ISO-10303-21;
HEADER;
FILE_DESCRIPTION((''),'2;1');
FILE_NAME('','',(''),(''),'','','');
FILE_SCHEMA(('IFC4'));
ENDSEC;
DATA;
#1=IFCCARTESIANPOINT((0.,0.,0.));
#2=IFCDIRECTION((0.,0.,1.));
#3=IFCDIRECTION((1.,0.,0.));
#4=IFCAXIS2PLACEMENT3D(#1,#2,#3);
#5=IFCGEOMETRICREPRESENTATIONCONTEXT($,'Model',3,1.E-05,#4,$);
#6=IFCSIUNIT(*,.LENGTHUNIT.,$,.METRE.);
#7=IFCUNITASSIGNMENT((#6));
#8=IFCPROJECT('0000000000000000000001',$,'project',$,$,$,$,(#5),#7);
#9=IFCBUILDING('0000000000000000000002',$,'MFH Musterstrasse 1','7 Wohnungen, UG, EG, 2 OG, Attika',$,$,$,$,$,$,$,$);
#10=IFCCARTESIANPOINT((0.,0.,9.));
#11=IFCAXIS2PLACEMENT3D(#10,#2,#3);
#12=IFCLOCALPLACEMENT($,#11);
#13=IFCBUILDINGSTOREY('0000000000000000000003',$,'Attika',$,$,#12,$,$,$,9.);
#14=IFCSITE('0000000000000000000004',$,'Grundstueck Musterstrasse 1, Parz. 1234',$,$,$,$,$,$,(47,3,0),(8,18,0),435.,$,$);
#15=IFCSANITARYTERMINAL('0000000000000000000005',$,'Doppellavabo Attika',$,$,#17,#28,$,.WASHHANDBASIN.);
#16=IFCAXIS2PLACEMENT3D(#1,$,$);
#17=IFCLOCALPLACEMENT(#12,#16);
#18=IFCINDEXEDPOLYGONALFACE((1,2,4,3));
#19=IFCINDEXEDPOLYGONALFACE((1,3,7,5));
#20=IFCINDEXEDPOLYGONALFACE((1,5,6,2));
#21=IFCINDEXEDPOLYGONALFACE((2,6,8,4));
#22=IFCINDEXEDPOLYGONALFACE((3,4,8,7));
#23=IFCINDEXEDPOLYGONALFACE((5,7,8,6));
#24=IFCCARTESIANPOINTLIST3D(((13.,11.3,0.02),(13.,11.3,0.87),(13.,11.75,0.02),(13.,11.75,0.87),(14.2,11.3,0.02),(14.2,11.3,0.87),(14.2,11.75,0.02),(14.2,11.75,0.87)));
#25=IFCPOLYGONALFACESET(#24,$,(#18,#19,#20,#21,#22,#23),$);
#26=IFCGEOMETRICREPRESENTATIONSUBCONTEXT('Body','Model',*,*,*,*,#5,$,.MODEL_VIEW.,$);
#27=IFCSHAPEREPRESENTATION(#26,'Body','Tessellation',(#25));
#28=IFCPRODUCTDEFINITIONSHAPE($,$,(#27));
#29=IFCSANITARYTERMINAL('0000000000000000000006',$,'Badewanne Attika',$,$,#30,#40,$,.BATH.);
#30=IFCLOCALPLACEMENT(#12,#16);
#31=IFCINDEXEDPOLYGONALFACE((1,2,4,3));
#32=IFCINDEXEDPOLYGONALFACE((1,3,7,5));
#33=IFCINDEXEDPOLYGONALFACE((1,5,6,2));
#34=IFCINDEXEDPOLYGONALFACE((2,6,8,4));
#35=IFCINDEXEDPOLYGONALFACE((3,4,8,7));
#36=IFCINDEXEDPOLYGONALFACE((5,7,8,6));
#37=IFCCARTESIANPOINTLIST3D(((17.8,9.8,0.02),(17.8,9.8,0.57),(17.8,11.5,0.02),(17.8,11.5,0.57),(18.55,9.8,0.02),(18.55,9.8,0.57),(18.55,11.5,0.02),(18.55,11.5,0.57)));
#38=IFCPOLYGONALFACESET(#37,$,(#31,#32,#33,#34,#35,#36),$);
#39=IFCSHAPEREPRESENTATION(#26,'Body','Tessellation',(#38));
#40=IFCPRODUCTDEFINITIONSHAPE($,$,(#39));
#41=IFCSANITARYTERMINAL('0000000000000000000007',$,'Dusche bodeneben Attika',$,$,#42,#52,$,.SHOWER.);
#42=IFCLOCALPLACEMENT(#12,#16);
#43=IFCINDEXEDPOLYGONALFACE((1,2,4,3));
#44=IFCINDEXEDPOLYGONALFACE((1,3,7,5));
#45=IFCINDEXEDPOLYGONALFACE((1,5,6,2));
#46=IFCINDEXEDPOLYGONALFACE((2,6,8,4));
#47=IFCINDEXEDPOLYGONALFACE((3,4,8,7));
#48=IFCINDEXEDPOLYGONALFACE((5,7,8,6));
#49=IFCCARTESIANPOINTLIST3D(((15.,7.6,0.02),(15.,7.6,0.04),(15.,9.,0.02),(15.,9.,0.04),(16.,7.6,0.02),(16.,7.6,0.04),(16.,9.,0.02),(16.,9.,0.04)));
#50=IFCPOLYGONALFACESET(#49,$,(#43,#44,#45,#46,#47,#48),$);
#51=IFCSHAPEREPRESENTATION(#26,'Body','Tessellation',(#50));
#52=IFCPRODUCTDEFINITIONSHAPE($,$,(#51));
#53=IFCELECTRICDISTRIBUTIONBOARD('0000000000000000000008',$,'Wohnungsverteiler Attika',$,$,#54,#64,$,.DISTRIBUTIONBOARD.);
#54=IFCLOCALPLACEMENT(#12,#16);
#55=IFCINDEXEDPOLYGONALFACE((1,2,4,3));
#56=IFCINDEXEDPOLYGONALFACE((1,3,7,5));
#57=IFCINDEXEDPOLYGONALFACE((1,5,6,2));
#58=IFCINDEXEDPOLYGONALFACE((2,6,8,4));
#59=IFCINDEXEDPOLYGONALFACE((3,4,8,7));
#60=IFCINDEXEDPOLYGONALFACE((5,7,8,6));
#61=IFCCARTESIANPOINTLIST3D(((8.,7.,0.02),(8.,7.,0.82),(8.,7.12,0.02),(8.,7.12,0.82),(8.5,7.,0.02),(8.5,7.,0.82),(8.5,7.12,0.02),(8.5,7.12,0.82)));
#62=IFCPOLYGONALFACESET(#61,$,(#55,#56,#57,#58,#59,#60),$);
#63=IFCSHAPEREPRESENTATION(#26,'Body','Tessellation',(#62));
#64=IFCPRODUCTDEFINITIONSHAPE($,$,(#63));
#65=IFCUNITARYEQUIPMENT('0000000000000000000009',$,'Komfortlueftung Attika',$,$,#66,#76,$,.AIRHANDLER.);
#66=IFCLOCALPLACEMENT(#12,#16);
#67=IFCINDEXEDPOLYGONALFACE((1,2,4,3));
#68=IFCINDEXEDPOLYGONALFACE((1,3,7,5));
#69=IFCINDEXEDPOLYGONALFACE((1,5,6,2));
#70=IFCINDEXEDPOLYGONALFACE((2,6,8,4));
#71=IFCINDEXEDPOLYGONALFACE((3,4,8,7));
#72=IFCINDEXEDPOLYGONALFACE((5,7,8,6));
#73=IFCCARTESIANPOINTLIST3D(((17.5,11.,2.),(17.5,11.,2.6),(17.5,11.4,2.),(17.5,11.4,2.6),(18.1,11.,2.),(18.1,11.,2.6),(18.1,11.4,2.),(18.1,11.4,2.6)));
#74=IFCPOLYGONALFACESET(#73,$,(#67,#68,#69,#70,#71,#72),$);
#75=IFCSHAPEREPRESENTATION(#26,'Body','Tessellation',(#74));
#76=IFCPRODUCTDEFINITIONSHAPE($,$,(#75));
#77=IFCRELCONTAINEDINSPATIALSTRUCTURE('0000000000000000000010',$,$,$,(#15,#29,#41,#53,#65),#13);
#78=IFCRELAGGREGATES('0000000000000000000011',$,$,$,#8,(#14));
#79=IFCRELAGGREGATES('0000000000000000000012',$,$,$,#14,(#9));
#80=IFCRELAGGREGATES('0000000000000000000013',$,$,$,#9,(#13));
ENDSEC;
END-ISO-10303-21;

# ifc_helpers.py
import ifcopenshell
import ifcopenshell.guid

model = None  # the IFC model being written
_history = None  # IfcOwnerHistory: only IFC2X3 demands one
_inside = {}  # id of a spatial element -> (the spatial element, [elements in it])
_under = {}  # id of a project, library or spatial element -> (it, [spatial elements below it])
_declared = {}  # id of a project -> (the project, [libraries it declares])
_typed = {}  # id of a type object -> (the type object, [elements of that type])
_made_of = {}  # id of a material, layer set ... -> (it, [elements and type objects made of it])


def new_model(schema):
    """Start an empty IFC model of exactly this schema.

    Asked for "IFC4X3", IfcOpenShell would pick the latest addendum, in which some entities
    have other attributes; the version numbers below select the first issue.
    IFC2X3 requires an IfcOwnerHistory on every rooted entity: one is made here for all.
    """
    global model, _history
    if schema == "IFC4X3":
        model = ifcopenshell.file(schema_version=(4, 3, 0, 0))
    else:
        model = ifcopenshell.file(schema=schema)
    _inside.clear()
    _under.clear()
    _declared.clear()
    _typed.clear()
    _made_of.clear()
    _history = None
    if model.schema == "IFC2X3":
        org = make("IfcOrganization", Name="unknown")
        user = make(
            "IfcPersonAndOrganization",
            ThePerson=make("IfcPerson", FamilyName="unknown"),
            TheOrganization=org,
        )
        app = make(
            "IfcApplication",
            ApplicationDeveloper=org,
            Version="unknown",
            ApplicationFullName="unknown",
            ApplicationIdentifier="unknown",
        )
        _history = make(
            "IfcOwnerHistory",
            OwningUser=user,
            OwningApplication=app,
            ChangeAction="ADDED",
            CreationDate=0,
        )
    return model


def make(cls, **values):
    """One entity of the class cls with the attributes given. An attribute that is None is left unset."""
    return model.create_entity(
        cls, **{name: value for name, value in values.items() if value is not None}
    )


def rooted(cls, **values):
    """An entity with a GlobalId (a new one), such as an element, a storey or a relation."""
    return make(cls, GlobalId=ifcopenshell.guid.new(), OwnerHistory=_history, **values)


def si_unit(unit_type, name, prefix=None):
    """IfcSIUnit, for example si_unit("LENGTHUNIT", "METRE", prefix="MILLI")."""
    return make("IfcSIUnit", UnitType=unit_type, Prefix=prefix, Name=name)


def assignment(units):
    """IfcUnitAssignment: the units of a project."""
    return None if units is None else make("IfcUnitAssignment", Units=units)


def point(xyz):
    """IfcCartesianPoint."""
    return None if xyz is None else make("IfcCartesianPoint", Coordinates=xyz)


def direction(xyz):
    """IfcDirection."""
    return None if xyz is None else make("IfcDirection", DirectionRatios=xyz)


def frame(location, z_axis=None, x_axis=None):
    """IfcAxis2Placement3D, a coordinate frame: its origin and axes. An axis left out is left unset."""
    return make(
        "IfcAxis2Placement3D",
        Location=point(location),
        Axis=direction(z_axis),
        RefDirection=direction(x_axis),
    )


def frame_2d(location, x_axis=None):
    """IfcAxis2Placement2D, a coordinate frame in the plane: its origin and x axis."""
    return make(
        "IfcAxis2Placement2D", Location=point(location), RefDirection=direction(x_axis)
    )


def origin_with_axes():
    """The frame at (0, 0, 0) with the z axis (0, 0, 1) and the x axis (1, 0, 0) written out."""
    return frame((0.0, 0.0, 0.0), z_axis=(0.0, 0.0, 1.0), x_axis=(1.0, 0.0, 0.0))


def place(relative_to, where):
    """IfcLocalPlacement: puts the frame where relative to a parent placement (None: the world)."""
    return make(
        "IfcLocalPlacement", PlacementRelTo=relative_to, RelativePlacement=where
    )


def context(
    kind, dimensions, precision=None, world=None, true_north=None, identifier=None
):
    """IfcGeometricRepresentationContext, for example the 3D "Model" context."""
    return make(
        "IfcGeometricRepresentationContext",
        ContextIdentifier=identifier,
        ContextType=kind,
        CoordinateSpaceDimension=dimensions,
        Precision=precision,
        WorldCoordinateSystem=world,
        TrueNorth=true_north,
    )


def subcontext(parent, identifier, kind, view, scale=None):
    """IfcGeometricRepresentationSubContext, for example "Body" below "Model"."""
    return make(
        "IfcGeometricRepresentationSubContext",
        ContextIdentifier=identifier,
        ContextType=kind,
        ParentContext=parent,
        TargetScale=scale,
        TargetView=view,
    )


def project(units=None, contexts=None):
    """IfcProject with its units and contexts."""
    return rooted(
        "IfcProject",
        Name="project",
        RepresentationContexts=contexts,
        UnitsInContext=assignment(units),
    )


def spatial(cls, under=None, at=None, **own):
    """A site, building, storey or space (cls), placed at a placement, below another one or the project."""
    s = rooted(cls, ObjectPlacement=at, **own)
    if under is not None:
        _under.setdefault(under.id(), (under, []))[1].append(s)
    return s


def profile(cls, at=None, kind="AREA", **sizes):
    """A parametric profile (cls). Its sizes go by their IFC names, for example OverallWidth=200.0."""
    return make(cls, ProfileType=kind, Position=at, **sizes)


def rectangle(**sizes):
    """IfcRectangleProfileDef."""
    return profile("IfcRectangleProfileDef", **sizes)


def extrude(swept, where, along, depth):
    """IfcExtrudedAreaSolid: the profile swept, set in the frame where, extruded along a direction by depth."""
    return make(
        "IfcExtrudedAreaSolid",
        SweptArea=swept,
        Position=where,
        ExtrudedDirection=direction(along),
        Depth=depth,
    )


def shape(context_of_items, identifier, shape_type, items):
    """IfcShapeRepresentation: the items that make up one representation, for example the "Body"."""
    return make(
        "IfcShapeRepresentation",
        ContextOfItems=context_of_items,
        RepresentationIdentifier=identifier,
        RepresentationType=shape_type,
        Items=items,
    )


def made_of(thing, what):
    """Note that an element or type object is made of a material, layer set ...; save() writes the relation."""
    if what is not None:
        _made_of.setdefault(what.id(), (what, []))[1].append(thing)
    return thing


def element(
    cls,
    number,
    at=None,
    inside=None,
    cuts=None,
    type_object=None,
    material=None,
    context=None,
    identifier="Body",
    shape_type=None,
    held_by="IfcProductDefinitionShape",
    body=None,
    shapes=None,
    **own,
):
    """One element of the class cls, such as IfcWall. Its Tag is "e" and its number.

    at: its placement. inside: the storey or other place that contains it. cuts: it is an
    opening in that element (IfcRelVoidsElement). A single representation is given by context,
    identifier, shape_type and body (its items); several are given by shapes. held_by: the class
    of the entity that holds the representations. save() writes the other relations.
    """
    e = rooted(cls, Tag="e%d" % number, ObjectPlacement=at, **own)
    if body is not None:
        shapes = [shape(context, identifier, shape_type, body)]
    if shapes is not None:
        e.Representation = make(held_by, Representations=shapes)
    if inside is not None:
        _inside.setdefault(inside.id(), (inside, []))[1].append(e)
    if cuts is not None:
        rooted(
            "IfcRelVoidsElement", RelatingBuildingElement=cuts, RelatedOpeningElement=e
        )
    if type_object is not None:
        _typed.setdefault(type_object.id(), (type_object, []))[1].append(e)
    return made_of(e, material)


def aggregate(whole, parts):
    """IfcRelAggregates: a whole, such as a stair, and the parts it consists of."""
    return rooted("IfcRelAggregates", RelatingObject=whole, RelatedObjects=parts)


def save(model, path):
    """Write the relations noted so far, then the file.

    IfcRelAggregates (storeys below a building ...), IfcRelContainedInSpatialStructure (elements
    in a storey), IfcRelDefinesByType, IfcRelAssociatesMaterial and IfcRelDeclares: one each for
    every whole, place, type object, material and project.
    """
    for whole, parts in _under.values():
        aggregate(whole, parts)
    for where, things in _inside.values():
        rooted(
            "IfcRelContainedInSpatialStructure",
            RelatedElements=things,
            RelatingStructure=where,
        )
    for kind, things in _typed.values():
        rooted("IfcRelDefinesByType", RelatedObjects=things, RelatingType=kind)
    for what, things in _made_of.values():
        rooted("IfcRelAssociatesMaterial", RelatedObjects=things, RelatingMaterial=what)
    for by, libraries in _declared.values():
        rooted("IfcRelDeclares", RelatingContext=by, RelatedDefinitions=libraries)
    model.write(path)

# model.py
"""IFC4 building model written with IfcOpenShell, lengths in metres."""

from ifc_helpers import new_model, si_unit, frame, frame_2d, origin_with_axes, place, context, subcontext, project, spatial, rectangle, extrude, element, save


model = new_model("IFC4")

# Units and contexts
model_context = context("Model", 3, precision=1e-05, world=origin_with_axes())
body_context = subcontext(model_context, "Body", "Model", "MODEL_VIEW")
ifc_project = project(units=[si_unit("LENGTHUNIT", "METRE")], contexts=[model_context])

# Site, building, storey
site = spatial("IfcSite", under=ifc_project, Name="Grundstueck Musterstrasse 1, Parz. 1234", RefLatitude=(47, 3, 0), RefLongitude=(8, 18, 0), RefElevation=435.0)
building = spatial("IfcBuilding", under=site, Name="MFH Musterstrasse 1", Description="7 Wohnungen, UG, EG, 2 OG, Attika")
storey_placement = place(None, frame((0.0, 0.0, 9.0), z_axis=(0.0, 0.0, 1.0), x_axis=(1.0, 0.0, 0.0)))
storey = spatial("IfcBuildingStorey", under=building, at=storey_placement, Name="Attika", Elevation=9.0)

# Sanitary terminals
sanitary_terminal_1_placement = place(storey_placement, frame((13.0, 11.3, 0.02), z_axis=(0.0, 0.0, 1.0), x_axis=(1.0, 0.0, 0.0)))
element("IfcSanitaryTerminal", 1, at=sanitary_terminal_1_placement, inside=storey, Name="Doppellavabo Attika", PredefinedType="WASHHANDBASIN", context=body_context, shape_type="SweptSolid", body=[
    extrude(rectangle(XDim=1.2, YDim=0.45, at=frame_2d((0.6, 0.225))), origin_with_axes(), (0.0, 0.0, 1.0), 0.85),
])
sanitary_terminal_2_placement = place(storey_placement, frame((17.8, 9.8, 0.02), z_axis=(0.0, 0.0, 1.0), x_axis=(1.0, 0.0, 0.0)))
element("IfcSanitaryTerminal", 2, at=sanitary_terminal_2_placement, inside=storey, Name="Badewanne Attika", PredefinedType="BATH", context=body_context, shape_type="SweptSolid", body=[
    extrude(rectangle(XDim=0.75, YDim=1.7, at=frame_2d((0.375, 0.85))), origin_with_axes(), (0.0, 0.0, 1.0), 0.55),
])
sanitary_terminal_3_placement = place(storey_placement, frame((15.0, 7.6, 0.02), z_axis=(0.0, 0.0, 1.0), x_axis=(1.0, 0.0, 0.0)))
element("IfcSanitaryTerminal", 3, at=sanitary_terminal_3_placement, inside=storey, Name="Dusche bodeneben Attika", PredefinedType="SHOWER", context=body_context, shape_type="SweptSolid", body=[
    extrude(rectangle(XDim=1.0, YDim=1.4, at=frame_2d((0.5, 0.7))), origin_with_axes(), (0.0, 0.0, 1.0), 0.02),
])

# Electric distribution board
electric_distribution_board_placement = place(storey_placement, frame((8.0, 7.0, 0.02), z_axis=(0.0, 0.0, 1.0), x_axis=(1.0, 0.0, 0.0)))
element("IfcElectricDistributionBoard", 4, at=electric_distribution_board_placement, inside=storey, Name="Wohnungsverteiler Attika", PredefinedType="DISTRIBUTIONBOARD", context=body_context, shape_type="SweptSolid", body=[
    extrude(rectangle(XDim=0.5, YDim=0.12, at=frame_2d((0.25, 0.06))), origin_with_axes(), (0.0, 0.0, 1.0), 0.8),
])

# Unitary equipment
unitary_equipment_placement = place(storey_placement, frame((17.5, 11.0, 2.0), z_axis=(0.0, 0.0, 1.0), x_axis=(1.0, 0.0, 0.0)))
element("IfcUnitaryEquipment", 5, at=unitary_equipment_placement, inside=storey, Name="Komfortlueftung Attika", PredefinedType="AIRHANDLER", context=body_context, shape_type="SweptSolid", body=[
    extrude(rectangle(XDim=0.6, YDim=0.4, at=frame_2d((0.3, 0.2))), origin_with_axes(), (0.0, 0.0, 1.0), 0.6),
])

save(model, "model.ifc")
